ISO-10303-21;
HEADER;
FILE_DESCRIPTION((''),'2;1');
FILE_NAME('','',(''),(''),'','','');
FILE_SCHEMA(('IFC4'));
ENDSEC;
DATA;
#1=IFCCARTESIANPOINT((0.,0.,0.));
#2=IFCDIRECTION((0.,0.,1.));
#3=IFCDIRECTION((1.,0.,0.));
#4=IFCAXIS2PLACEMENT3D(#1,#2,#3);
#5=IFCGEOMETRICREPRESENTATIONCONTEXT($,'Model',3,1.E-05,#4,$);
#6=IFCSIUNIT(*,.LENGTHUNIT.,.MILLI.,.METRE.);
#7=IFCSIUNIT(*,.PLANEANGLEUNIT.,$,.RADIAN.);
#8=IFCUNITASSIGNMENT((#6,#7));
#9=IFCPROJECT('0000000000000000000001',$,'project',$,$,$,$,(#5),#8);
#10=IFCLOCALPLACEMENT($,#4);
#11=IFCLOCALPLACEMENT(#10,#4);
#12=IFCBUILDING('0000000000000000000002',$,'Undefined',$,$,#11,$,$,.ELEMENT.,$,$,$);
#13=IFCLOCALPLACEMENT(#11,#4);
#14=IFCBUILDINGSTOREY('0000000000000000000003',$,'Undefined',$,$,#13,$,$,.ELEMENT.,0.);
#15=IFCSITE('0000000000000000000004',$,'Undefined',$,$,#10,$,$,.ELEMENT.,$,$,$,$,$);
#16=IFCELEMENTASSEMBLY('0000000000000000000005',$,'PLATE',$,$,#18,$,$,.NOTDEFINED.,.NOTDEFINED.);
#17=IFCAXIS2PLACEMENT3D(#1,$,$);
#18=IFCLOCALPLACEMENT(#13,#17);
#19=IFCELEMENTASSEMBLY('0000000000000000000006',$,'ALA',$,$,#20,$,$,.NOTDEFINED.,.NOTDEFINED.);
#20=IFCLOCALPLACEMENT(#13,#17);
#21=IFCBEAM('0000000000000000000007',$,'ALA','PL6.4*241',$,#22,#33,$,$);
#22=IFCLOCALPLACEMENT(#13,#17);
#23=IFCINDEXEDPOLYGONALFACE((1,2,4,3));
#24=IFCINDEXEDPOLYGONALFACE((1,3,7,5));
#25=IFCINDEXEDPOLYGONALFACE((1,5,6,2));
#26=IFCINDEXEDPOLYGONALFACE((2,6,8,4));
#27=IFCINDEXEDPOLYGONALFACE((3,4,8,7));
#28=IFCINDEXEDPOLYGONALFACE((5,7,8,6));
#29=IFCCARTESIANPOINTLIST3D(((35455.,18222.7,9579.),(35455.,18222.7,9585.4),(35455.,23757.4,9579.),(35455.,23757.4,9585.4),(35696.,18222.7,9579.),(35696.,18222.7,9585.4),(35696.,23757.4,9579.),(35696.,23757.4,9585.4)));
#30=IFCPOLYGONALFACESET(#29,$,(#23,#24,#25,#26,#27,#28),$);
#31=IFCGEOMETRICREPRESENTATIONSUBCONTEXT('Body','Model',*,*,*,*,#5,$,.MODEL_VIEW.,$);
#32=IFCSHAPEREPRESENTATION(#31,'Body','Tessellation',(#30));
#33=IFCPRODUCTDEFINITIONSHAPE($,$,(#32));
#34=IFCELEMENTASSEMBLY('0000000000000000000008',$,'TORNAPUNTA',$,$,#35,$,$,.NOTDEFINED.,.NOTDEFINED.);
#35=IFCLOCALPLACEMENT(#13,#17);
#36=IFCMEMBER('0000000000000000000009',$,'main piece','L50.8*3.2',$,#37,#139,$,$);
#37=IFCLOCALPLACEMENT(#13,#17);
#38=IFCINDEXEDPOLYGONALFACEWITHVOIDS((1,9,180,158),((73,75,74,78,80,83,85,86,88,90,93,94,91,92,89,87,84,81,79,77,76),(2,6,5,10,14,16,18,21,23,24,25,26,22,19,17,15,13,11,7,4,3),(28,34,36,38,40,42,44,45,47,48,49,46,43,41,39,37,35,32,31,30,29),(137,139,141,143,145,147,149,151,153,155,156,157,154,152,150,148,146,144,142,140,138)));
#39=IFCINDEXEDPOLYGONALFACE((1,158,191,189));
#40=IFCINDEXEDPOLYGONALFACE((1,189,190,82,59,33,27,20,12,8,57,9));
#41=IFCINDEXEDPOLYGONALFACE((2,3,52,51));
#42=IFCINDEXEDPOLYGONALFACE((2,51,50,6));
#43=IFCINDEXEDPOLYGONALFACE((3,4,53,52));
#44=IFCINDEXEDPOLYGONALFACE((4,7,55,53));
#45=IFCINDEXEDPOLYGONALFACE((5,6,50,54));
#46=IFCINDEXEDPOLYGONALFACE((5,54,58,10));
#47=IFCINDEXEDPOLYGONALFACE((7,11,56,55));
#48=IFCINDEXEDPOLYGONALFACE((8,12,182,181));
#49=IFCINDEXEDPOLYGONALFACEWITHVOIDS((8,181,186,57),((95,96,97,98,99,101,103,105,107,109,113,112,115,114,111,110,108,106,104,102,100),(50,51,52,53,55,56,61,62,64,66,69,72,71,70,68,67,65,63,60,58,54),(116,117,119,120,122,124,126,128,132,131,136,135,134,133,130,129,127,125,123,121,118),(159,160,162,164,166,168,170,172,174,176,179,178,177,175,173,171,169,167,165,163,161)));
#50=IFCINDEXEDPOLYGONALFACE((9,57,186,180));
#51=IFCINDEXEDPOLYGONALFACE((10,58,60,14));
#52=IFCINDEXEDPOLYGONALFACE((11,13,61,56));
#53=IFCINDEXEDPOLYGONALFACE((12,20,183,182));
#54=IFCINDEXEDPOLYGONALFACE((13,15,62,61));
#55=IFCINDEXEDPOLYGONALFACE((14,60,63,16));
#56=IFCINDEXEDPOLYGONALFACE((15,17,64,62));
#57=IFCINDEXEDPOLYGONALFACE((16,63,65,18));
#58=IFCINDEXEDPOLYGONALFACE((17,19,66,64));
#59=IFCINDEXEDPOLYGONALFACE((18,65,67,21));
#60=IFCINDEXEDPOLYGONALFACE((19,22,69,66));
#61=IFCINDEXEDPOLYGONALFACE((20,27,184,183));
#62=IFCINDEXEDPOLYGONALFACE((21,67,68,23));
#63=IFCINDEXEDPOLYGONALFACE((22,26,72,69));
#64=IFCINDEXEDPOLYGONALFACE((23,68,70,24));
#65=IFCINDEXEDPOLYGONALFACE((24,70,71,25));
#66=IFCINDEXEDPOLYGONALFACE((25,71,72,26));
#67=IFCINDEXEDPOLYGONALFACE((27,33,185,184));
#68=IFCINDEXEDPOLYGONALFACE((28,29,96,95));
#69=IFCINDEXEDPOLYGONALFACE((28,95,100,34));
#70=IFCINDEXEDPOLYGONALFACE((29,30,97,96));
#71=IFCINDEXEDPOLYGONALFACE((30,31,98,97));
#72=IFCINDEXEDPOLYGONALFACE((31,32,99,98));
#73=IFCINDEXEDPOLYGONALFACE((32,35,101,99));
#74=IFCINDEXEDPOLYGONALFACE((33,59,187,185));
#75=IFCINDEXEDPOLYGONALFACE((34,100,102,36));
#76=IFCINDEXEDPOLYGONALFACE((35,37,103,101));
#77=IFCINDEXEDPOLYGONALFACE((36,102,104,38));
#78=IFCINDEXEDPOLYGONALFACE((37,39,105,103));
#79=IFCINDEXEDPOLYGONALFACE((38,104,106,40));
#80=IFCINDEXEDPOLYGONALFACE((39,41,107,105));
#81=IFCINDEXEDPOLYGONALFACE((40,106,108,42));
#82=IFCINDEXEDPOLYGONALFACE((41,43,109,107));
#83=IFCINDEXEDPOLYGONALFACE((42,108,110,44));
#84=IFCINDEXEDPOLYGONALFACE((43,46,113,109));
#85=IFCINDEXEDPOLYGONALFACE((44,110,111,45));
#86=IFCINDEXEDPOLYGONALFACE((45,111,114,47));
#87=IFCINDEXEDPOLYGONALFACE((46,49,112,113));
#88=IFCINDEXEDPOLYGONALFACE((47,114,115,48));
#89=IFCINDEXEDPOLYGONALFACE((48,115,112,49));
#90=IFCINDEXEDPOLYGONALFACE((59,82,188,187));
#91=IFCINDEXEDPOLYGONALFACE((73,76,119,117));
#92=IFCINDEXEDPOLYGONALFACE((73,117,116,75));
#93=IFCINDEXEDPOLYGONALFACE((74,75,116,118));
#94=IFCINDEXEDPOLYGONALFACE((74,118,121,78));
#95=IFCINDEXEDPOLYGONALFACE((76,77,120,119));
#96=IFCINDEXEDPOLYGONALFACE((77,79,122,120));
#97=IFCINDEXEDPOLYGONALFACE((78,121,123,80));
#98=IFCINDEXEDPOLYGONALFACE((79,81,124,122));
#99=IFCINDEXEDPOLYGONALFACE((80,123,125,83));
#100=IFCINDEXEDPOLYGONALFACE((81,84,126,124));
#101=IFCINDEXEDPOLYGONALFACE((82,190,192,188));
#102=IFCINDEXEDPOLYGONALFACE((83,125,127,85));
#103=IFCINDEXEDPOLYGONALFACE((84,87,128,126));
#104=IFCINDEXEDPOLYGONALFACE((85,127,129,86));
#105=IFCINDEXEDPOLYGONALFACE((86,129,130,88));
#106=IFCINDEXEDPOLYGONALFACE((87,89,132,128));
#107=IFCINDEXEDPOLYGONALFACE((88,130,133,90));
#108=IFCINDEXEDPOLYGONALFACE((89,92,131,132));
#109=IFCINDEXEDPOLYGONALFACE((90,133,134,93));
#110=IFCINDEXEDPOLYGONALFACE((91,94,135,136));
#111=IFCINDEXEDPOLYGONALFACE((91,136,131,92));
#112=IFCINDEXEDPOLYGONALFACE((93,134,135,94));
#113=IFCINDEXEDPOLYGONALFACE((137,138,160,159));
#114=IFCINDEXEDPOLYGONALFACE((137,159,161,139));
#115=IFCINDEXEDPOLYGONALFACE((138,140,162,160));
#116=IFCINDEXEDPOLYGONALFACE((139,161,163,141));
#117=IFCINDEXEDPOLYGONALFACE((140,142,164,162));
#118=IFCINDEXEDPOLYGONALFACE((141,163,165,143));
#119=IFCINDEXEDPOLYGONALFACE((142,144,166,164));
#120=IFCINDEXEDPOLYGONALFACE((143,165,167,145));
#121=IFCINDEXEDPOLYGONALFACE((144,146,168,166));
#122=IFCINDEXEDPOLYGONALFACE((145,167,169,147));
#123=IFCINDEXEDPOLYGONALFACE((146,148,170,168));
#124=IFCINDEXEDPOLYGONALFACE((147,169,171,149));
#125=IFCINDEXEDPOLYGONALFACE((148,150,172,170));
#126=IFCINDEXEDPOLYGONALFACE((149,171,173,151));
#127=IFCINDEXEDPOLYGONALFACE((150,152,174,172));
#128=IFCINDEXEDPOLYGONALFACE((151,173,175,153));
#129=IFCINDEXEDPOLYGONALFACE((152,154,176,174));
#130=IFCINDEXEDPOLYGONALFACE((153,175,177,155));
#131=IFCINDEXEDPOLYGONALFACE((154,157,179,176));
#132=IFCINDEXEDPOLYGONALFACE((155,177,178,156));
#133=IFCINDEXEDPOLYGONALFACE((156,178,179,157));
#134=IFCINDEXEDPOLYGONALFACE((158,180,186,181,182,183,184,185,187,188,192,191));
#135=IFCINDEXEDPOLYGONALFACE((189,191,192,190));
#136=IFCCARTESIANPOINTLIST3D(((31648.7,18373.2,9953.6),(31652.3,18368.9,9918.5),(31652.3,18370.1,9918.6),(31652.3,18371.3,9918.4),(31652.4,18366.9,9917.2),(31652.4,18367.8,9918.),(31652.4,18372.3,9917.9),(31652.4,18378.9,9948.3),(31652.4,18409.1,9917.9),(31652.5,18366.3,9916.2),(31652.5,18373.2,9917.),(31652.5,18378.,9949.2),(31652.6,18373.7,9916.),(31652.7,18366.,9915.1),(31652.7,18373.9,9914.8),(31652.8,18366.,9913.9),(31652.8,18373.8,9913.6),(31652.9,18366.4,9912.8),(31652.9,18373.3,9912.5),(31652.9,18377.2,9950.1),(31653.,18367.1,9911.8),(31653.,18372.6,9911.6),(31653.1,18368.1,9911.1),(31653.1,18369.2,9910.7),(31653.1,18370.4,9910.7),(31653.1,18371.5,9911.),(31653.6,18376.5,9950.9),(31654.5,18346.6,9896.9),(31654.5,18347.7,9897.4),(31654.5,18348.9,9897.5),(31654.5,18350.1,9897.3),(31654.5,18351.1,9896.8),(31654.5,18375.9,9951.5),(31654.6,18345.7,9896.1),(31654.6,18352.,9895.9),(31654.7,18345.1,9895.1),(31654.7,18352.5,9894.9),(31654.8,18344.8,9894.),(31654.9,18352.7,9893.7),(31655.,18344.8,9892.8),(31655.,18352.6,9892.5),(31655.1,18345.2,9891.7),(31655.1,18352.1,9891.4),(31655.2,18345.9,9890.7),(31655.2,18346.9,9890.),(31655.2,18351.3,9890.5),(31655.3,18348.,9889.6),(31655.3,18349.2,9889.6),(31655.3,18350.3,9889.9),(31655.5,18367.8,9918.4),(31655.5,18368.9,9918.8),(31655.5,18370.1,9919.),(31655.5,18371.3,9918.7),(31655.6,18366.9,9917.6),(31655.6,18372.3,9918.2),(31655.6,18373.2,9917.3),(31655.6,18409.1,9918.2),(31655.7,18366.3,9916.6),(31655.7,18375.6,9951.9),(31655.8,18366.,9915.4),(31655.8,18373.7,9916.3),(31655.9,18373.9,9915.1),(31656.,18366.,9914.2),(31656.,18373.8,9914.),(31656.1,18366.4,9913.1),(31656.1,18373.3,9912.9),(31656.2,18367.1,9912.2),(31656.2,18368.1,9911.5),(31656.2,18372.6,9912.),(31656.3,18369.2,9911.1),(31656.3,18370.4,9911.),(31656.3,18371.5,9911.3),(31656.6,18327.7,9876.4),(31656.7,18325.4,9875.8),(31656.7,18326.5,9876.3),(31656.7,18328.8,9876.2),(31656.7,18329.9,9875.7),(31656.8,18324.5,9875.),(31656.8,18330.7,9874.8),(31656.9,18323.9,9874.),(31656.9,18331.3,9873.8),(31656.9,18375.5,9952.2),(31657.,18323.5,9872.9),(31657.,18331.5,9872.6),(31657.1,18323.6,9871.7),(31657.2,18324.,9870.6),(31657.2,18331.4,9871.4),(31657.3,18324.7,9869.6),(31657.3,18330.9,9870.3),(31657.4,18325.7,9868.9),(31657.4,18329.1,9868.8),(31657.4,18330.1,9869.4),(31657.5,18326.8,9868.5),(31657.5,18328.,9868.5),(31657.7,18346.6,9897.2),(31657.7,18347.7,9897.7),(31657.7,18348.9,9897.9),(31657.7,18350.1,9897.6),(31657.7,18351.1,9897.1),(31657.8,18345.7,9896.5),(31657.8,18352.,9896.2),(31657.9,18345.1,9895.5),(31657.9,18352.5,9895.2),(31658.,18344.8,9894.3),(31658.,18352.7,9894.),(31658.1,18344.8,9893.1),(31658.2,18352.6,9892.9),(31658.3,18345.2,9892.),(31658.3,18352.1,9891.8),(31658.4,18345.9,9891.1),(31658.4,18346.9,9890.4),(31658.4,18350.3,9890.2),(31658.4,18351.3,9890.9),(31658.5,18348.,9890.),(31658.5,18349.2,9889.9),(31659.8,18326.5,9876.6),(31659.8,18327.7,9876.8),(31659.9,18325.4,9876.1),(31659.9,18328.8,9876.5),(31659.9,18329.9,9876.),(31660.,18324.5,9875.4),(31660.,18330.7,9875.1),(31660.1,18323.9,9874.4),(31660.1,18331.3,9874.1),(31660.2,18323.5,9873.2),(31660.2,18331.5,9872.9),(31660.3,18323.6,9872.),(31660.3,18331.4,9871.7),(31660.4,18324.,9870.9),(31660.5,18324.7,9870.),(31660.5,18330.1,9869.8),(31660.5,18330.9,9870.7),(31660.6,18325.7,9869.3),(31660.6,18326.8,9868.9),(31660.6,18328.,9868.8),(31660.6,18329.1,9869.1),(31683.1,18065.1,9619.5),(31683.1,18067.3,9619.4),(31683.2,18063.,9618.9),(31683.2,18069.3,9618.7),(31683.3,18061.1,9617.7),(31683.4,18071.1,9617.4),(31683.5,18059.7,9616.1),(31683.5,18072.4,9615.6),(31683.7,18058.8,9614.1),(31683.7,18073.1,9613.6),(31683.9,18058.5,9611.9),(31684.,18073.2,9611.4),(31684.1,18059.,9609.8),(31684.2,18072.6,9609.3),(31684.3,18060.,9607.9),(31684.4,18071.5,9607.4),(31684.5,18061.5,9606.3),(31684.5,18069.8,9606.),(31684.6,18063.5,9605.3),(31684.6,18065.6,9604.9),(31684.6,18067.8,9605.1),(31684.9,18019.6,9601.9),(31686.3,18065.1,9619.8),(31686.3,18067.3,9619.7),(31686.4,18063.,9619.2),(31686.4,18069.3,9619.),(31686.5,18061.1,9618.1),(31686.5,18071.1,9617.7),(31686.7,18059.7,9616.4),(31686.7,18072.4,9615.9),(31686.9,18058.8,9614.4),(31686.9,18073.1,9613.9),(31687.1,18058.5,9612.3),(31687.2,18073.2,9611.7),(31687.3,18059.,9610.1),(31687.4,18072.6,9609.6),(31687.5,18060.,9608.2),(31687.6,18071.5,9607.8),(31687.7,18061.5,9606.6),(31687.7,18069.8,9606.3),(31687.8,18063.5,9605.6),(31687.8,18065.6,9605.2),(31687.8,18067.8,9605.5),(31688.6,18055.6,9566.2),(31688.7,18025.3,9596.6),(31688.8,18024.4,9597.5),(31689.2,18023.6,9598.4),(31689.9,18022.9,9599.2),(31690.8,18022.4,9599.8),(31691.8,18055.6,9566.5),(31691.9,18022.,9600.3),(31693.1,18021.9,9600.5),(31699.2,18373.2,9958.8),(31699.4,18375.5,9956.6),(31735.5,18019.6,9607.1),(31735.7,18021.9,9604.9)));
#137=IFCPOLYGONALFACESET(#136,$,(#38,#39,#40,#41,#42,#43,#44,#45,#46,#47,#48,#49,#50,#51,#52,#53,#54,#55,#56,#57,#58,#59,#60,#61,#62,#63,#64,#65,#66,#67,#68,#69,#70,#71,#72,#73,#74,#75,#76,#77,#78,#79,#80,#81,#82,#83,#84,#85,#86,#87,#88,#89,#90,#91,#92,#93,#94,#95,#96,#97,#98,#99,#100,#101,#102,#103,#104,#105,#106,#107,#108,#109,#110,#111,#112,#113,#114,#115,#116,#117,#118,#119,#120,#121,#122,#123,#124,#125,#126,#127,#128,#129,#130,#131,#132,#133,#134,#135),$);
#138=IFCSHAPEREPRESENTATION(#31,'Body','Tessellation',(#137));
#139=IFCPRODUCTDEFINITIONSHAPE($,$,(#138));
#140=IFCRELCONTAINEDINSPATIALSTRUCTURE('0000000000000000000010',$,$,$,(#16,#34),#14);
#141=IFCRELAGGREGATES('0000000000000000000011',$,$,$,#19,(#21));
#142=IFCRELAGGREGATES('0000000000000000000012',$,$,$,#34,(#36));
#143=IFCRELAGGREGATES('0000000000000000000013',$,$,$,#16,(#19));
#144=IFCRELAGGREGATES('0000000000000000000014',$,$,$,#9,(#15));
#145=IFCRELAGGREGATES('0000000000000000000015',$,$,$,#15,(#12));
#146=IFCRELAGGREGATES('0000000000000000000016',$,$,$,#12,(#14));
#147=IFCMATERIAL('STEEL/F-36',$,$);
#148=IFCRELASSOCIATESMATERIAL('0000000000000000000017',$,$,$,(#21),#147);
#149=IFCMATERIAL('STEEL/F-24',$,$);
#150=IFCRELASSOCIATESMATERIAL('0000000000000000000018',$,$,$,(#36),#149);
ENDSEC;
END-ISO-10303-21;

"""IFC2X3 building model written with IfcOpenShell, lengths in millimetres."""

from ifc_helpers import new_model, si_unit, frame, origin_with_axes, origin_2d_with_axis, place, context, subcontext, project, spatial, rectangle, circle, l_section, extrude, source, transform, mapped, material, element, aggregate, save


model = new_model("IFC2X3")

# Units and contexts
model_context = context("Model", 3, precision=1e-05, world=origin_with_axes())
body_context = subcontext(model_context, "Body", "Model", "MODEL_VIEW")
ifc_project = project(units=[si_unit("LENGTHUNIT", "METRE", prefix="MILLI"), si_unit("PLANEANGLEUNIT", "RADIAN")], contexts=[model_context])

# Site, building, storey
site_placement = place(None, origin_with_axes())
site = spatial("IfcSite", under=ifc_project, at=site_placement, Name="Undefined", CompositionType="ELEMENT")
building_placement = place(site_placement, origin_with_axes())
building = spatial("IfcBuilding", under=site, at=building_placement, Name="Undefined", CompositionType="ELEMENT")
storey_placement = place(building_placement, origin_with_axes())
storey = spatial("IfcBuildingStorey", under=building, at=storey_placement, Name="Undefined", CompositionType="ELEMENT", Elevation=0.0)

# Element assemblies, beam
assembly_1_placement = place(storey_placement, origin_with_axes())
assembly_1 = element("IfcElementAssembly", 1, at=assembly_1_placement, inside=storey, Name="PLATE", AssemblyPlace="NOTDEFINED", PredefinedType="NOTDEFINED")
assembly_2_placement = place(assembly_1_placement, origin_with_axes())
assembly_2 = element("IfcElementAssembly", 2, at=assembly_2_placement, Name="ALA", AssemblyPlace="NOTDEFINED", PredefinedType="NOTDEFINED")
ifc_material_1 = material(Name="STEEL/F-36")
beam_1_placement = place(assembly_2_placement, frame((35575.5, 18222.7, 9582.2), z_axis=(1.0, 0.0, 0.0), x_axis=(0.0, 1.0, 0.0)))
beam_1 = element("IfcBeam", 3, at=beam_1_placement, material=ifc_material_1, Name="ALA", Description="PL6.4*241", context=body_context, shape_type="SweptSolid", body=[
    extrude(rectangle(XDim=6.4, YDim=241.0, at=origin_2d_with_axis()), frame((5534.7, 0.0, 0.0), z_axis=(-1.0, 0.0, 0.0), x_axis=(0.0, -1.0, 0.0)), (0.0, 0.0, 1.0), 5534.7),
])
aggregate(assembly_2, [beam_1])

# Element assembly, member, openings
assembly_3_placement = place(storey_placement, origin_with_axes())
assembly_3 = element("IfcElementAssembly", 4, at=assembly_3_placement, inside=storey, Name="TORNAPUNTA", AssemblyPlace="NOTDEFINED", PredefinedType="NOTDEFINED")
ifc_material_2 = material(Name="STEEL/F-24")
member_1_placement = place(assembly_3_placement, frame((31712.1, 18037.6, 9586.7), z_axis=(0.994727, 0.0, 0.102562), x_axis=(-0.072522, 0.707107, 0.703378)))
member_1 = element("IfcMember", 5, at=member_1_placement, material=ifc_material_2, Name="main piece", Description="L50.8*3.2", context=body_context, shape_type="SweptSolid", body=[
    extrude(l_section(Depth=50.8, Width=50.8, Thickness=3.2, FilletRadius=4.8, at=origin_2d_with_axis()), frame((500.0, 0.0, 0.0), z_axis=(-1.0, 0.0, 0.0), x_axis=(0.0, -1.0, 0.0)), (0.0, 0.0, 1.0), 500.0),
])
shared_shape_1 = source(origin_with_axes(), body_context, "Body", "SweptSolid", [
    extrude(circle(Radius=4.0, at=origin_2d_with_axis()), frame((0.0, -3.3, 0.0), z_axis=(0.0, 1.0, 0.0), x_axis=(1.0, 0.0, 0.0)), (0.0, 0.0, 1.0), 3.4),
])
opening_1_placement = place(assembly_3_placement, frame((31652.7, 18369.9, 9914.7), z_axis=(0.072522, 0.707107, -0.703378), x_axis=(0.072522, -0.707107, -0.703378)))
element("IfcOpeningElement", 6, at=opening_1_placement, cuts=member_1, ObjectType="Opening", context=body_context, shape_type="MappedRepresentation", body=[
    mapped(shared_shape_1, transform((0.0, 0.0, 0.0))),
    mapped(shared_shape_1, transform((30.0, 0.0, 0.0))),
    mapped(shared_shape_1, transform((60.0, 0.0, 0.0))),
])
shared_shape_2 = source(origin_with_axes(), body_context, "Body", "SweptSolid", [
    extrude(circle(Radius=7.3, at=origin_2d_with_axis()), frame((0.0, -3.3, 0.0), z_axis=(0.0, 1.0, 0.0), x_axis=(1.0, 0.0, 0.0)), (0.0, 0.0, 1.0), 3.4),
])
opening_2_placement = place(assembly_3_placement, frame((31683.9, 18065.9, 9612.2), z_axis=(-0.072522, -0.707107, 0.703378), x_axis=(-0.072522, 0.707107, 0.703378)))
element("IfcOpeningElement", 7, at=opening_2_placement, cuts=member_1, ObjectType="Opening", context=body_context, shape_type="MappedRepresentation", body=[
    mapped(shared_shape_2, transform((0.0, 0.0, 0.0))),
])
aggregate(assembly_3, [member_1])

aggregate(assembly_1, [assembly_2])

save(model, "model.ifc")
